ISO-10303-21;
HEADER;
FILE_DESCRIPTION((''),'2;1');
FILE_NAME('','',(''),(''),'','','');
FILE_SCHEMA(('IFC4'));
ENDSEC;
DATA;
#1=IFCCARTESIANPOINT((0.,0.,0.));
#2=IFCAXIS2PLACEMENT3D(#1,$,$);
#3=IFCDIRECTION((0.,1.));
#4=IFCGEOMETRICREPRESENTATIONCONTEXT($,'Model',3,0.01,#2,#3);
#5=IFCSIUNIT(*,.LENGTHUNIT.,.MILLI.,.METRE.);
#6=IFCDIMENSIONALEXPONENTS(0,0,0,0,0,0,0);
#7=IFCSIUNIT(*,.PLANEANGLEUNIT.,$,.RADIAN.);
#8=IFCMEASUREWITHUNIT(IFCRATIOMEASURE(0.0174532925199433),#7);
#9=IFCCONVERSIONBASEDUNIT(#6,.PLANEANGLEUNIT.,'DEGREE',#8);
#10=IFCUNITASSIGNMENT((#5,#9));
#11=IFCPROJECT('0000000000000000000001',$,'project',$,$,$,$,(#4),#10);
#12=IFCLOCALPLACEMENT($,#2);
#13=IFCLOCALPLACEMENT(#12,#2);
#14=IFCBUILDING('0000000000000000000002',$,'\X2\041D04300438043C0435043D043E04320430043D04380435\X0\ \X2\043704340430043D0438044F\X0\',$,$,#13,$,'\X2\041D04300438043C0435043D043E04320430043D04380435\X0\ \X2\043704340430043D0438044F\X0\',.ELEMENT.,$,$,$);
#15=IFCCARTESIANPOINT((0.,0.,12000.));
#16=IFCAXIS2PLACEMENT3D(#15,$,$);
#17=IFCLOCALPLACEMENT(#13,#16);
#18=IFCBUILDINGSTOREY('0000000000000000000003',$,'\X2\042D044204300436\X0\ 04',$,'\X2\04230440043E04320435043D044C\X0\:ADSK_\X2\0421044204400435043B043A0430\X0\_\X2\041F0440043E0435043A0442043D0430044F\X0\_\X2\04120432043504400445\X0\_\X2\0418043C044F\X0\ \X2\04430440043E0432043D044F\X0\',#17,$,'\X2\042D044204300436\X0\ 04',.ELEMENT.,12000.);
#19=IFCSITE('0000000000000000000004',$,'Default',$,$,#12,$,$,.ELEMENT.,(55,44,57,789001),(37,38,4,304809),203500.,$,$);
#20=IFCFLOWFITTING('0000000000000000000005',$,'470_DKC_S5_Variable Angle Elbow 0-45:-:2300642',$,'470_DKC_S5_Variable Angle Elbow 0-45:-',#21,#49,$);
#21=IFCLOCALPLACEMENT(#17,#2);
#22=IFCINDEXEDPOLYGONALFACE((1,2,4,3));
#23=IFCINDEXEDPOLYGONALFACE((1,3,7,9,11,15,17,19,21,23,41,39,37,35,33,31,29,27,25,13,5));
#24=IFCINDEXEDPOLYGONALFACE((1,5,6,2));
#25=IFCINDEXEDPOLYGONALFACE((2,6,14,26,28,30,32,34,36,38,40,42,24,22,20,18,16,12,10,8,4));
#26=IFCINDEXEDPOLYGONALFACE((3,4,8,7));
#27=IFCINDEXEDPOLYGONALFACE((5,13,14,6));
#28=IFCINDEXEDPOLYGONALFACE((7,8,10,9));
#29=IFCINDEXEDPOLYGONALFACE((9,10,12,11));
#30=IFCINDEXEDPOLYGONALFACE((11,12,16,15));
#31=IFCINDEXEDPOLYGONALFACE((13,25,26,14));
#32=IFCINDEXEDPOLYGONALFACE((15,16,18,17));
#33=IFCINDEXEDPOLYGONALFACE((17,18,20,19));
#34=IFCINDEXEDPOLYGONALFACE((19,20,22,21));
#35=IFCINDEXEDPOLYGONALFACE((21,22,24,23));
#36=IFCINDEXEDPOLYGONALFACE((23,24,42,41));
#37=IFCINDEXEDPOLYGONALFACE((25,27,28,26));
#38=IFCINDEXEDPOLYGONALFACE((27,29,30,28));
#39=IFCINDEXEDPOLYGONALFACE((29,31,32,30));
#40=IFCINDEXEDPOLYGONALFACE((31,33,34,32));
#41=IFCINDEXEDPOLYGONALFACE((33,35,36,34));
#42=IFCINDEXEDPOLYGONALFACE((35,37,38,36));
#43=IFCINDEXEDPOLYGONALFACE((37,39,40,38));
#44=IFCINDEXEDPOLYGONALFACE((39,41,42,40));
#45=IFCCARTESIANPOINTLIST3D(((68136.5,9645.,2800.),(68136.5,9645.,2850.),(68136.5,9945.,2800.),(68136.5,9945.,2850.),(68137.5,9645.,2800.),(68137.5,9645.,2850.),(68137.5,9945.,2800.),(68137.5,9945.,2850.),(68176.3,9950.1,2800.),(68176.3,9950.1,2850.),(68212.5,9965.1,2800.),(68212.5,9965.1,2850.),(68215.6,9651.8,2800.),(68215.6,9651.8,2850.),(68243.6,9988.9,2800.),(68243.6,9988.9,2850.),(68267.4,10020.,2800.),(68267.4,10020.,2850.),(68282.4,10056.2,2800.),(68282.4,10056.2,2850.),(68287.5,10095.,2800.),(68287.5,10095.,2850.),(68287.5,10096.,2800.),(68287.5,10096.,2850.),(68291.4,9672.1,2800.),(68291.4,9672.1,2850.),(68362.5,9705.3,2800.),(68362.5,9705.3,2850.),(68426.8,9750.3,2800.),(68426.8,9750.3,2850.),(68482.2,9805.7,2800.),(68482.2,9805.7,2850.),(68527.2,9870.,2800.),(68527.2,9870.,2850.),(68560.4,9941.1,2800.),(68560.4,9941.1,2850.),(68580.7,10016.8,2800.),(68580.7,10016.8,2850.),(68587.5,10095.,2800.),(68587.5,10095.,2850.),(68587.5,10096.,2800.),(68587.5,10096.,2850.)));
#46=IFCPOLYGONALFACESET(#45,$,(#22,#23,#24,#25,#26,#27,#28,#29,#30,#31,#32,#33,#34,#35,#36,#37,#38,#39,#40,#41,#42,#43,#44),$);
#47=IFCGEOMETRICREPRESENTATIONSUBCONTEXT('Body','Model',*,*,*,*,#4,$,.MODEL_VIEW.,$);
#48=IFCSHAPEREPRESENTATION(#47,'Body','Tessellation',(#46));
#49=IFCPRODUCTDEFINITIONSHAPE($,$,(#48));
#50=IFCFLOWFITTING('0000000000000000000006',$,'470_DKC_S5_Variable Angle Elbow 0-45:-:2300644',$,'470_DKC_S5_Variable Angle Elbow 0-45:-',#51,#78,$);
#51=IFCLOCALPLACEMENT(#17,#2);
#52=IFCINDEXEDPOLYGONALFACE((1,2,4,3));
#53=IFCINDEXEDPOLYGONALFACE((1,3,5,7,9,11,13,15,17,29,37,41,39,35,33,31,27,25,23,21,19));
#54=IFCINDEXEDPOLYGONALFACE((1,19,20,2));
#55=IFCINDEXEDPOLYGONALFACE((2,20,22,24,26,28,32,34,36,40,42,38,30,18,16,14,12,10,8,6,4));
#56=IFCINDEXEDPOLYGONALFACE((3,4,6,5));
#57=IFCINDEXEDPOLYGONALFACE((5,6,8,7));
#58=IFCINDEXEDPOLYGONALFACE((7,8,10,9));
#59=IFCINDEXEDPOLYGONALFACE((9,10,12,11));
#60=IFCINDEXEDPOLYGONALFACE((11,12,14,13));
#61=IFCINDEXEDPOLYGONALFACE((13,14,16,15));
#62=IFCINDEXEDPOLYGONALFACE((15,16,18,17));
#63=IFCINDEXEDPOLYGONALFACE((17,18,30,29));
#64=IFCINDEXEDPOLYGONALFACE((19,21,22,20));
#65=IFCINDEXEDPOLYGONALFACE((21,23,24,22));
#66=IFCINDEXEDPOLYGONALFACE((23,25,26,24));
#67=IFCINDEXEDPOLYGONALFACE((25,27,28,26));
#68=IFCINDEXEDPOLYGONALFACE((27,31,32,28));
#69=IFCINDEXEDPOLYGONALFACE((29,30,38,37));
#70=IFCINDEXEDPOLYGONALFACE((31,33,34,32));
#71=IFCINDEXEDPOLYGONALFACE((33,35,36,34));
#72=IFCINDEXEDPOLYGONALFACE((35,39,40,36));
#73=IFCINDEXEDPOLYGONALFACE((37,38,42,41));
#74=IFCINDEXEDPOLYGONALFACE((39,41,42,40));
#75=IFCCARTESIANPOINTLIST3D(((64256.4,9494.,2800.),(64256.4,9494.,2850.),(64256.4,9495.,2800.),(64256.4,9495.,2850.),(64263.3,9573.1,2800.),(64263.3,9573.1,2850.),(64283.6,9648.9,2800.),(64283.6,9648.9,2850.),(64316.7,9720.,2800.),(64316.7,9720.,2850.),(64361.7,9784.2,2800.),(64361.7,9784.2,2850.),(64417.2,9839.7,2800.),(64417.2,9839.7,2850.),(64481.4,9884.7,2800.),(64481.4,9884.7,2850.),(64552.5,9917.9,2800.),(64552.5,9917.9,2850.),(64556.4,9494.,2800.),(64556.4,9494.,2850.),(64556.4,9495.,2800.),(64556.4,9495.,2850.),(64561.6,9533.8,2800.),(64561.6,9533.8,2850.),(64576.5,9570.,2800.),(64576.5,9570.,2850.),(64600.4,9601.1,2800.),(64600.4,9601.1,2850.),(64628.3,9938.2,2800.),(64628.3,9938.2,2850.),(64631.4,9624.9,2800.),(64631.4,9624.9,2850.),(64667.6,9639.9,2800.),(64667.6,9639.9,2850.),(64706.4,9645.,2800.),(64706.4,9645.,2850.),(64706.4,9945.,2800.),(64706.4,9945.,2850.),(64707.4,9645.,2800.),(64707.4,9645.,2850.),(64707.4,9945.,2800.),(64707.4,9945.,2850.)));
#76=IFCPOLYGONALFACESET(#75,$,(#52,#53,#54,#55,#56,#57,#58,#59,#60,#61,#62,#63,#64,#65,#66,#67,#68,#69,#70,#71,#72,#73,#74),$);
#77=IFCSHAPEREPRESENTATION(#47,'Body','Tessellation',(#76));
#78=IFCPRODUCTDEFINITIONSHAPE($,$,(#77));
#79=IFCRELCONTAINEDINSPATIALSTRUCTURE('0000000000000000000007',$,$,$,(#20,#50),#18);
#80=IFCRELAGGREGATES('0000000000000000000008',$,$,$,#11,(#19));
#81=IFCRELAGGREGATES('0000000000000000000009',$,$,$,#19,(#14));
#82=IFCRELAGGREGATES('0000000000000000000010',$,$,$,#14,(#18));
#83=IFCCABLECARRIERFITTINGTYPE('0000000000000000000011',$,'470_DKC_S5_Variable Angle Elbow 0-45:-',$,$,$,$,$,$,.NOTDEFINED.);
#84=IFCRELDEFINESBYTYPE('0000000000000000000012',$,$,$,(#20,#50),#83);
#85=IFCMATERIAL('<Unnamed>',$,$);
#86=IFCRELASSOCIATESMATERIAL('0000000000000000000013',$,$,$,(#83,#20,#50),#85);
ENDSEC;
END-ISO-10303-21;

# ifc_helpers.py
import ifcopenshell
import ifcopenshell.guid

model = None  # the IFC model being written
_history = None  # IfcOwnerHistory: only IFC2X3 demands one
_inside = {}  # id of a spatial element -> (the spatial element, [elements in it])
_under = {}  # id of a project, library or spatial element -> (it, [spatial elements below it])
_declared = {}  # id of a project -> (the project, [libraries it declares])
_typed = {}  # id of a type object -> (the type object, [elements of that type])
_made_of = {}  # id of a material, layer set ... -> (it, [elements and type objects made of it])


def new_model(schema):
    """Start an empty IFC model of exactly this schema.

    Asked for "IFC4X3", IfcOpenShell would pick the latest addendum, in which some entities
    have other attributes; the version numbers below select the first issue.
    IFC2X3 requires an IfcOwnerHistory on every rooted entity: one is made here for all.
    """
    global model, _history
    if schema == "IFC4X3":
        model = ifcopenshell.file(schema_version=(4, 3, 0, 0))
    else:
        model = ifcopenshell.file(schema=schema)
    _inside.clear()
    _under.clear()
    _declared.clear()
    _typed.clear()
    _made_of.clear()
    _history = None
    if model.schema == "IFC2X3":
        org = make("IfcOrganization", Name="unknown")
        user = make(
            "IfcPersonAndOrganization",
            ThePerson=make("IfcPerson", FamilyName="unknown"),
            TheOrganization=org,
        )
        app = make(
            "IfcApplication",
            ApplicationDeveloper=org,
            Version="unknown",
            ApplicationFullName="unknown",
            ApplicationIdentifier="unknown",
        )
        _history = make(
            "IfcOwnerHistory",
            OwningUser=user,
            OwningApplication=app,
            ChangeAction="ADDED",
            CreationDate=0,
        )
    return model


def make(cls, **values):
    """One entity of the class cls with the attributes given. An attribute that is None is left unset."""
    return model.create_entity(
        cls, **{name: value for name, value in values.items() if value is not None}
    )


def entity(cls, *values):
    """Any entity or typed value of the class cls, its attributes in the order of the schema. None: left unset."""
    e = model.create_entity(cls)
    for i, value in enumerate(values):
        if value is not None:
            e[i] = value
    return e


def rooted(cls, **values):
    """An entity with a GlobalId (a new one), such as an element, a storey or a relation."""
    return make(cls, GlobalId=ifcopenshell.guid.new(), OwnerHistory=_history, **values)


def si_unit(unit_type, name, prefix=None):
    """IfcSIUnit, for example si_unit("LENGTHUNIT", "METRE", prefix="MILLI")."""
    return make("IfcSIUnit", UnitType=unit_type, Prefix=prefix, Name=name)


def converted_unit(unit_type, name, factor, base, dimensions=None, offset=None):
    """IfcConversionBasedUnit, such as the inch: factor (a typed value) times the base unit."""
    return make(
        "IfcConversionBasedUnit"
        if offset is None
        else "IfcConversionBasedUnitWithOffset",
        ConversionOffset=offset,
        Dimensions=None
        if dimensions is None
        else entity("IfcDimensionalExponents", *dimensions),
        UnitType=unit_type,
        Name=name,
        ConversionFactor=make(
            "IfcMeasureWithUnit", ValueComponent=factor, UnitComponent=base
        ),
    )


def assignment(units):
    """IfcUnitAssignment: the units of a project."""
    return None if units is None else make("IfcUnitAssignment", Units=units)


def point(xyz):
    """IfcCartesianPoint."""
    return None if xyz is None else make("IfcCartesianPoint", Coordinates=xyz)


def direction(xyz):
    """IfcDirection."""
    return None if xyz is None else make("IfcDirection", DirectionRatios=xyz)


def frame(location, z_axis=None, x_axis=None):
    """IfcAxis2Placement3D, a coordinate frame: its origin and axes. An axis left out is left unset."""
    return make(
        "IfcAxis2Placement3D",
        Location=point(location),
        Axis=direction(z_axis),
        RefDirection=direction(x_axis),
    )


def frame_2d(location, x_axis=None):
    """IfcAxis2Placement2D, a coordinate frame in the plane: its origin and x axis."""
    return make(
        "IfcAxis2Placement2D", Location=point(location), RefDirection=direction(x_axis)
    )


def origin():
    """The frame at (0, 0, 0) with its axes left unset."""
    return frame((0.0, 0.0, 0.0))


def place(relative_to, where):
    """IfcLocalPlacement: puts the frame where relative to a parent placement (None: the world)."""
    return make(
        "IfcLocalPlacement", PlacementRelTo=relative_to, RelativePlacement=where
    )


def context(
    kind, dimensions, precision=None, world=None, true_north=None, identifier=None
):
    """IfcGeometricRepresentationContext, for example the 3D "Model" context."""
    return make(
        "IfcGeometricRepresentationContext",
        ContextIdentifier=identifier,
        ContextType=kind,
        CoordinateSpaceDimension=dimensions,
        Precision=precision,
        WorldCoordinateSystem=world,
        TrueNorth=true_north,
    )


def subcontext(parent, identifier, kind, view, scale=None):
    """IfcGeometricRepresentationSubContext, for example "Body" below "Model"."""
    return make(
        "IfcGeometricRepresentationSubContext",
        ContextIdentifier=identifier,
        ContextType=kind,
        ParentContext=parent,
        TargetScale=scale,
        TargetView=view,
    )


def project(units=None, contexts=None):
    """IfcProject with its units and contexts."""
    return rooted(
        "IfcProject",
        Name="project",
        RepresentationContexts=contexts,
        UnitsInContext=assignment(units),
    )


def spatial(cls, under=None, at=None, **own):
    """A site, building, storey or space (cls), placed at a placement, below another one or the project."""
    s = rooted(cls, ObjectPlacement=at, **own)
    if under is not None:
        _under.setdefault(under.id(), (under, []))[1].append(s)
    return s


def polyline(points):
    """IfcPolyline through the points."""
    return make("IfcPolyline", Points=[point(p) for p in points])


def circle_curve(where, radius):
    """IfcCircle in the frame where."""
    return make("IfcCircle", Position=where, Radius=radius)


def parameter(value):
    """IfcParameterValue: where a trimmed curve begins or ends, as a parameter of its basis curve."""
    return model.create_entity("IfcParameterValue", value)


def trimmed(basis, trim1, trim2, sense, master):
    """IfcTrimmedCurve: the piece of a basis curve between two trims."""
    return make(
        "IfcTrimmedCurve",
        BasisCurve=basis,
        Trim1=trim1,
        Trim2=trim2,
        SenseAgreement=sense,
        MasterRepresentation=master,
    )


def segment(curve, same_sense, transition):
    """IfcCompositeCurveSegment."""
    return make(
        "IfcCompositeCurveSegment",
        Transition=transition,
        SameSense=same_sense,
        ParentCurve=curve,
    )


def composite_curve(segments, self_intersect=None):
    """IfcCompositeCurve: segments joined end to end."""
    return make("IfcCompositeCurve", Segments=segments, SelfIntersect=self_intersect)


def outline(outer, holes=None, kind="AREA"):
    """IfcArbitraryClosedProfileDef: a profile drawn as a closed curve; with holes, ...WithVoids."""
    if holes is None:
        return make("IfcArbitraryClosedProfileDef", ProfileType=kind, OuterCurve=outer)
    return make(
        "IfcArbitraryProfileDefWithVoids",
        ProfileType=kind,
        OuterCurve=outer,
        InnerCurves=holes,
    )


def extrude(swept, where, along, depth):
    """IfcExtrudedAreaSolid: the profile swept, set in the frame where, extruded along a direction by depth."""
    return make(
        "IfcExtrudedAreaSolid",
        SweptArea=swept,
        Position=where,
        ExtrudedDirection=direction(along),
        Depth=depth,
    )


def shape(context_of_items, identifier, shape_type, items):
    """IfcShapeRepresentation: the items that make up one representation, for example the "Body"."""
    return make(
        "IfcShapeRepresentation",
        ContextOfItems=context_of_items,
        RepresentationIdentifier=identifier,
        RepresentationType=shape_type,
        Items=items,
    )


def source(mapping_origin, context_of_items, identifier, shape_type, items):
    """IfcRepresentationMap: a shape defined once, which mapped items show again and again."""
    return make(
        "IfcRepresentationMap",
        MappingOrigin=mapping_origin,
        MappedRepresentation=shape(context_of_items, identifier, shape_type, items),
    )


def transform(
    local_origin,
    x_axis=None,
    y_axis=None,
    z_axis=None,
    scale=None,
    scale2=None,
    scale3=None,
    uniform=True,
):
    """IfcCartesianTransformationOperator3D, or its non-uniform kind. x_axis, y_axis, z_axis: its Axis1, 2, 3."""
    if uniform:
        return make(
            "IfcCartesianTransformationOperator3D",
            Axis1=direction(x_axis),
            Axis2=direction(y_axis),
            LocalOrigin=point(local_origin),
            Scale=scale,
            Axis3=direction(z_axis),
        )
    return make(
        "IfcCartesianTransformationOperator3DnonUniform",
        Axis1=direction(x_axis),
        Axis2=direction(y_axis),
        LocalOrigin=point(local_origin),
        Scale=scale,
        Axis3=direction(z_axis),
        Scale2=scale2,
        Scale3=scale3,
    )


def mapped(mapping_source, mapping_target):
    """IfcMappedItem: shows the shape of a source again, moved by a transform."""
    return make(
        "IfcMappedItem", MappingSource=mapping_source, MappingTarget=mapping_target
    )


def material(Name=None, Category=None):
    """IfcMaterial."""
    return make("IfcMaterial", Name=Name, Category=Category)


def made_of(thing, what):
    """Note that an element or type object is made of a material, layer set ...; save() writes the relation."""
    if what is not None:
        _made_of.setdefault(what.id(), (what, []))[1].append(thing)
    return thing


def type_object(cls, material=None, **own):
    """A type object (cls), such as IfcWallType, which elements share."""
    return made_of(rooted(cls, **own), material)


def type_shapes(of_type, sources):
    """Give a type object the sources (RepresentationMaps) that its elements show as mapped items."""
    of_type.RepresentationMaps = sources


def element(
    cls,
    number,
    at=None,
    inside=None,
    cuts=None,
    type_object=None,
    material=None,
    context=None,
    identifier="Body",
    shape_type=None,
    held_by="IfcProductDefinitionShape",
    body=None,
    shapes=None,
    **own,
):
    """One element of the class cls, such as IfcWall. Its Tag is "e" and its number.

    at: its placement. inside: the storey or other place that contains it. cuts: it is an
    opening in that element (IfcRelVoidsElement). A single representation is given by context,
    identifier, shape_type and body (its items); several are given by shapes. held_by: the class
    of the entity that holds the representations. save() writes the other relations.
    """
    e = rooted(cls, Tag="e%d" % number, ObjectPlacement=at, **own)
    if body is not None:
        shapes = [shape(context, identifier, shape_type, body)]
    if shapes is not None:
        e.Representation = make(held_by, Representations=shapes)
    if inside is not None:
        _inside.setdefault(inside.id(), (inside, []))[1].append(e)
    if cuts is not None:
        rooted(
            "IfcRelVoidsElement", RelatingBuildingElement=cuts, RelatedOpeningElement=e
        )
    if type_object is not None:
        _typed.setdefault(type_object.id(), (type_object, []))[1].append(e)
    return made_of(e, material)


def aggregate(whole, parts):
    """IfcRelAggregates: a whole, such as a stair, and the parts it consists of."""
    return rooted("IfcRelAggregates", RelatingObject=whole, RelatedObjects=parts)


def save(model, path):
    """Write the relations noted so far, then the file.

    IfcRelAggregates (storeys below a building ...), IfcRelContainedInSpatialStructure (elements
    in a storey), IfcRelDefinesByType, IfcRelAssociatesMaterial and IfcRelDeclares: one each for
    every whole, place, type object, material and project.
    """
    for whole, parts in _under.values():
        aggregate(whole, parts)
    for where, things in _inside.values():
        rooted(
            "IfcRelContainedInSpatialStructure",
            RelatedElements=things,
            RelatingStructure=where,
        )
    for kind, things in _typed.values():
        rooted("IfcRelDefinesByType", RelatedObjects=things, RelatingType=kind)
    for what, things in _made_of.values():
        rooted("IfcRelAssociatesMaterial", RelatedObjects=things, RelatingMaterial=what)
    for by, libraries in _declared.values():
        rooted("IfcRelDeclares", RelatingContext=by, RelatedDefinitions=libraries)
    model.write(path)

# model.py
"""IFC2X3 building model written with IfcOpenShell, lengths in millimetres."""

from ifc_helpers import new_model, entity, si_unit, converted_unit, direction, frame, frame_2d, origin, place, context, subcontext, project, spatial, polyline, circle_curve, parameter, trimmed, segment, composite_curve, outline, extrude, source, transform, mapped, material, type_object, type_shapes, element, save


model = new_model("IFC2X3")

# Units and contexts
model_context = context("Model", 3, precision=0.01, world=origin(), true_north=direction((0.0, 1.0)))
body_context = subcontext(model_context, "Body", "Model", "MODEL_VIEW")
ifc_project = project(units=[si_unit("LENGTHUNIT", "METRE", prefix="MILLI"), converted_unit("PLANEANGLEUNIT", "DEGREE", entity("IfcRatioMeasure", 0.0174532925199433), si_unit("PLANEANGLEUNIT", "RADIAN"), dimensions=[0, 0, 0, 0, 0, 0, 0])], contexts=[model_context])

# Site, building, storey
site_placement = place(None, origin())
site = spatial("IfcSite", under=ifc_project, at=site_placement, Name="Default", CompositionType="ELEMENT", RefLatitude=(55, 44, 57, 789001), RefLongitude=(37, 38, 4, 304809), RefElevation=203500.0)
building_placement = place(site_placement, origin())
building = spatial("IfcBuilding", under=site, at=building_placement, Name="Наименование здания", LongName="Наименование здания", CompositionType="ELEMENT")
storey_placement = place(building_placement, frame((0.0, 0.0, 12000.0)))
storey = spatial("IfcBuildingStorey", under=building, at=storey_placement, Name="Этаж 04", ObjectType="Уровень:ADSK_Стрелка_Проектная_Вверх_Имя уровня", LongName="Этаж 04", CompositionType="ELEMENT", Elevation=12000.0)

# Flow fittings
ifc_material = material(Name="<Unnamed>")
cable_carrier_fitting_type_1 = type_object("IfcCableCarrierFittingType", Name="470_DKC_S5_Variable Angle Elbow 0-45:-", PredefinedType="NOTDEFINED", material=ifc_material)
shared_shape_1 = source(origin(), body_context, "Body", "SweptSolid", [
    extrude(outline(composite_curve([segment(polyline([(-150.8, -300.2), (-149.8, -300.2)]), True, "CONTINUOUS"), segment(trimmed(circle_curve(frame_2d((-149.8, 149.8), x_axis=(0.0, -1.0)), 450.0), [parameter(0.0)], [parameter(90.0)], True, "PARAMETER"), True, "CONTINUOUS"), segment(polyline([(300.2, 149.8), (300.2, 150.8)]), True, "CONTINUOUS"), segment(polyline([(300.2, 150.8), (0.2, 150.8)]), True, "CONTINUOUS"), segment(polyline([(0.2, 150.8), (0.2, 149.8)]), True, "CONTINUOUS"), segment(trimmed(circle_curve(frame_2d((-149.8, 149.8), x_axis=(0.0, -1.0)), 150.0), [parameter(0.0)], [parameter(90.0)], True, "PARAMETER"), False, "CONTINUOUS"), segment(polyline([(-149.8, -0.2), (-150.8, -0.2)]), True, "CONTINUOUS"), segment(polyline([(-150.8, -0.2), (-150.8, -300.2)]), True, "CONTINUOUS")], self_intersect=False)), frame((-150.2, 150.2, -25.0)), (0.0, 0.0, 1.0), 50.0),
])
type_shapes(cable_carrier_fitting_type_1, [shared_shape_1])
for number, where, name in (
    (1, (68437.5, 9795.0, 2825.0), "470_DKC_S5_Variable Angle Elbow 0-45:-:2300642"),
):
    element("IfcFlowFitting", number, at=place(storey_placement, frame(where)), inside=storey, type_object=cable_carrier_fitting_type_1, material=ifc_material, Name=name, ObjectType="470_DKC_S5_Variable Angle Elbow 0-45:-", context=body_context, shape_type="MappedRepresentation", body=[
        mapped(shared_shape_1, transform((0.0, 0.0, 0.0), scale=1.0)),
    ])
flow_fitting_1_placement = place(storey_placement, frame((64406.4, 9795.0, 2825.0), z_axis=(0.0, 0.0, 1.0), x_axis=(-1.0, 0.0, 0.0)))
element("IfcFlowFitting", 2, at=flow_fitting_1_placement, inside=storey, type_object=cable_carrier_fitting_type_1, material=ifc_material, Name="470_DKC_S5_Variable Angle Elbow 0-45:-:2300644", ObjectType="470_DKC_S5_Variable Angle Elbow 0-45:-", context=body_context, shape_type="MappedRepresentation", body=[
    mapped(shared_shape_1, transform((0.0, 0.0, 0.0), scale=1.0)),
])

save(model, "model.ifc")
